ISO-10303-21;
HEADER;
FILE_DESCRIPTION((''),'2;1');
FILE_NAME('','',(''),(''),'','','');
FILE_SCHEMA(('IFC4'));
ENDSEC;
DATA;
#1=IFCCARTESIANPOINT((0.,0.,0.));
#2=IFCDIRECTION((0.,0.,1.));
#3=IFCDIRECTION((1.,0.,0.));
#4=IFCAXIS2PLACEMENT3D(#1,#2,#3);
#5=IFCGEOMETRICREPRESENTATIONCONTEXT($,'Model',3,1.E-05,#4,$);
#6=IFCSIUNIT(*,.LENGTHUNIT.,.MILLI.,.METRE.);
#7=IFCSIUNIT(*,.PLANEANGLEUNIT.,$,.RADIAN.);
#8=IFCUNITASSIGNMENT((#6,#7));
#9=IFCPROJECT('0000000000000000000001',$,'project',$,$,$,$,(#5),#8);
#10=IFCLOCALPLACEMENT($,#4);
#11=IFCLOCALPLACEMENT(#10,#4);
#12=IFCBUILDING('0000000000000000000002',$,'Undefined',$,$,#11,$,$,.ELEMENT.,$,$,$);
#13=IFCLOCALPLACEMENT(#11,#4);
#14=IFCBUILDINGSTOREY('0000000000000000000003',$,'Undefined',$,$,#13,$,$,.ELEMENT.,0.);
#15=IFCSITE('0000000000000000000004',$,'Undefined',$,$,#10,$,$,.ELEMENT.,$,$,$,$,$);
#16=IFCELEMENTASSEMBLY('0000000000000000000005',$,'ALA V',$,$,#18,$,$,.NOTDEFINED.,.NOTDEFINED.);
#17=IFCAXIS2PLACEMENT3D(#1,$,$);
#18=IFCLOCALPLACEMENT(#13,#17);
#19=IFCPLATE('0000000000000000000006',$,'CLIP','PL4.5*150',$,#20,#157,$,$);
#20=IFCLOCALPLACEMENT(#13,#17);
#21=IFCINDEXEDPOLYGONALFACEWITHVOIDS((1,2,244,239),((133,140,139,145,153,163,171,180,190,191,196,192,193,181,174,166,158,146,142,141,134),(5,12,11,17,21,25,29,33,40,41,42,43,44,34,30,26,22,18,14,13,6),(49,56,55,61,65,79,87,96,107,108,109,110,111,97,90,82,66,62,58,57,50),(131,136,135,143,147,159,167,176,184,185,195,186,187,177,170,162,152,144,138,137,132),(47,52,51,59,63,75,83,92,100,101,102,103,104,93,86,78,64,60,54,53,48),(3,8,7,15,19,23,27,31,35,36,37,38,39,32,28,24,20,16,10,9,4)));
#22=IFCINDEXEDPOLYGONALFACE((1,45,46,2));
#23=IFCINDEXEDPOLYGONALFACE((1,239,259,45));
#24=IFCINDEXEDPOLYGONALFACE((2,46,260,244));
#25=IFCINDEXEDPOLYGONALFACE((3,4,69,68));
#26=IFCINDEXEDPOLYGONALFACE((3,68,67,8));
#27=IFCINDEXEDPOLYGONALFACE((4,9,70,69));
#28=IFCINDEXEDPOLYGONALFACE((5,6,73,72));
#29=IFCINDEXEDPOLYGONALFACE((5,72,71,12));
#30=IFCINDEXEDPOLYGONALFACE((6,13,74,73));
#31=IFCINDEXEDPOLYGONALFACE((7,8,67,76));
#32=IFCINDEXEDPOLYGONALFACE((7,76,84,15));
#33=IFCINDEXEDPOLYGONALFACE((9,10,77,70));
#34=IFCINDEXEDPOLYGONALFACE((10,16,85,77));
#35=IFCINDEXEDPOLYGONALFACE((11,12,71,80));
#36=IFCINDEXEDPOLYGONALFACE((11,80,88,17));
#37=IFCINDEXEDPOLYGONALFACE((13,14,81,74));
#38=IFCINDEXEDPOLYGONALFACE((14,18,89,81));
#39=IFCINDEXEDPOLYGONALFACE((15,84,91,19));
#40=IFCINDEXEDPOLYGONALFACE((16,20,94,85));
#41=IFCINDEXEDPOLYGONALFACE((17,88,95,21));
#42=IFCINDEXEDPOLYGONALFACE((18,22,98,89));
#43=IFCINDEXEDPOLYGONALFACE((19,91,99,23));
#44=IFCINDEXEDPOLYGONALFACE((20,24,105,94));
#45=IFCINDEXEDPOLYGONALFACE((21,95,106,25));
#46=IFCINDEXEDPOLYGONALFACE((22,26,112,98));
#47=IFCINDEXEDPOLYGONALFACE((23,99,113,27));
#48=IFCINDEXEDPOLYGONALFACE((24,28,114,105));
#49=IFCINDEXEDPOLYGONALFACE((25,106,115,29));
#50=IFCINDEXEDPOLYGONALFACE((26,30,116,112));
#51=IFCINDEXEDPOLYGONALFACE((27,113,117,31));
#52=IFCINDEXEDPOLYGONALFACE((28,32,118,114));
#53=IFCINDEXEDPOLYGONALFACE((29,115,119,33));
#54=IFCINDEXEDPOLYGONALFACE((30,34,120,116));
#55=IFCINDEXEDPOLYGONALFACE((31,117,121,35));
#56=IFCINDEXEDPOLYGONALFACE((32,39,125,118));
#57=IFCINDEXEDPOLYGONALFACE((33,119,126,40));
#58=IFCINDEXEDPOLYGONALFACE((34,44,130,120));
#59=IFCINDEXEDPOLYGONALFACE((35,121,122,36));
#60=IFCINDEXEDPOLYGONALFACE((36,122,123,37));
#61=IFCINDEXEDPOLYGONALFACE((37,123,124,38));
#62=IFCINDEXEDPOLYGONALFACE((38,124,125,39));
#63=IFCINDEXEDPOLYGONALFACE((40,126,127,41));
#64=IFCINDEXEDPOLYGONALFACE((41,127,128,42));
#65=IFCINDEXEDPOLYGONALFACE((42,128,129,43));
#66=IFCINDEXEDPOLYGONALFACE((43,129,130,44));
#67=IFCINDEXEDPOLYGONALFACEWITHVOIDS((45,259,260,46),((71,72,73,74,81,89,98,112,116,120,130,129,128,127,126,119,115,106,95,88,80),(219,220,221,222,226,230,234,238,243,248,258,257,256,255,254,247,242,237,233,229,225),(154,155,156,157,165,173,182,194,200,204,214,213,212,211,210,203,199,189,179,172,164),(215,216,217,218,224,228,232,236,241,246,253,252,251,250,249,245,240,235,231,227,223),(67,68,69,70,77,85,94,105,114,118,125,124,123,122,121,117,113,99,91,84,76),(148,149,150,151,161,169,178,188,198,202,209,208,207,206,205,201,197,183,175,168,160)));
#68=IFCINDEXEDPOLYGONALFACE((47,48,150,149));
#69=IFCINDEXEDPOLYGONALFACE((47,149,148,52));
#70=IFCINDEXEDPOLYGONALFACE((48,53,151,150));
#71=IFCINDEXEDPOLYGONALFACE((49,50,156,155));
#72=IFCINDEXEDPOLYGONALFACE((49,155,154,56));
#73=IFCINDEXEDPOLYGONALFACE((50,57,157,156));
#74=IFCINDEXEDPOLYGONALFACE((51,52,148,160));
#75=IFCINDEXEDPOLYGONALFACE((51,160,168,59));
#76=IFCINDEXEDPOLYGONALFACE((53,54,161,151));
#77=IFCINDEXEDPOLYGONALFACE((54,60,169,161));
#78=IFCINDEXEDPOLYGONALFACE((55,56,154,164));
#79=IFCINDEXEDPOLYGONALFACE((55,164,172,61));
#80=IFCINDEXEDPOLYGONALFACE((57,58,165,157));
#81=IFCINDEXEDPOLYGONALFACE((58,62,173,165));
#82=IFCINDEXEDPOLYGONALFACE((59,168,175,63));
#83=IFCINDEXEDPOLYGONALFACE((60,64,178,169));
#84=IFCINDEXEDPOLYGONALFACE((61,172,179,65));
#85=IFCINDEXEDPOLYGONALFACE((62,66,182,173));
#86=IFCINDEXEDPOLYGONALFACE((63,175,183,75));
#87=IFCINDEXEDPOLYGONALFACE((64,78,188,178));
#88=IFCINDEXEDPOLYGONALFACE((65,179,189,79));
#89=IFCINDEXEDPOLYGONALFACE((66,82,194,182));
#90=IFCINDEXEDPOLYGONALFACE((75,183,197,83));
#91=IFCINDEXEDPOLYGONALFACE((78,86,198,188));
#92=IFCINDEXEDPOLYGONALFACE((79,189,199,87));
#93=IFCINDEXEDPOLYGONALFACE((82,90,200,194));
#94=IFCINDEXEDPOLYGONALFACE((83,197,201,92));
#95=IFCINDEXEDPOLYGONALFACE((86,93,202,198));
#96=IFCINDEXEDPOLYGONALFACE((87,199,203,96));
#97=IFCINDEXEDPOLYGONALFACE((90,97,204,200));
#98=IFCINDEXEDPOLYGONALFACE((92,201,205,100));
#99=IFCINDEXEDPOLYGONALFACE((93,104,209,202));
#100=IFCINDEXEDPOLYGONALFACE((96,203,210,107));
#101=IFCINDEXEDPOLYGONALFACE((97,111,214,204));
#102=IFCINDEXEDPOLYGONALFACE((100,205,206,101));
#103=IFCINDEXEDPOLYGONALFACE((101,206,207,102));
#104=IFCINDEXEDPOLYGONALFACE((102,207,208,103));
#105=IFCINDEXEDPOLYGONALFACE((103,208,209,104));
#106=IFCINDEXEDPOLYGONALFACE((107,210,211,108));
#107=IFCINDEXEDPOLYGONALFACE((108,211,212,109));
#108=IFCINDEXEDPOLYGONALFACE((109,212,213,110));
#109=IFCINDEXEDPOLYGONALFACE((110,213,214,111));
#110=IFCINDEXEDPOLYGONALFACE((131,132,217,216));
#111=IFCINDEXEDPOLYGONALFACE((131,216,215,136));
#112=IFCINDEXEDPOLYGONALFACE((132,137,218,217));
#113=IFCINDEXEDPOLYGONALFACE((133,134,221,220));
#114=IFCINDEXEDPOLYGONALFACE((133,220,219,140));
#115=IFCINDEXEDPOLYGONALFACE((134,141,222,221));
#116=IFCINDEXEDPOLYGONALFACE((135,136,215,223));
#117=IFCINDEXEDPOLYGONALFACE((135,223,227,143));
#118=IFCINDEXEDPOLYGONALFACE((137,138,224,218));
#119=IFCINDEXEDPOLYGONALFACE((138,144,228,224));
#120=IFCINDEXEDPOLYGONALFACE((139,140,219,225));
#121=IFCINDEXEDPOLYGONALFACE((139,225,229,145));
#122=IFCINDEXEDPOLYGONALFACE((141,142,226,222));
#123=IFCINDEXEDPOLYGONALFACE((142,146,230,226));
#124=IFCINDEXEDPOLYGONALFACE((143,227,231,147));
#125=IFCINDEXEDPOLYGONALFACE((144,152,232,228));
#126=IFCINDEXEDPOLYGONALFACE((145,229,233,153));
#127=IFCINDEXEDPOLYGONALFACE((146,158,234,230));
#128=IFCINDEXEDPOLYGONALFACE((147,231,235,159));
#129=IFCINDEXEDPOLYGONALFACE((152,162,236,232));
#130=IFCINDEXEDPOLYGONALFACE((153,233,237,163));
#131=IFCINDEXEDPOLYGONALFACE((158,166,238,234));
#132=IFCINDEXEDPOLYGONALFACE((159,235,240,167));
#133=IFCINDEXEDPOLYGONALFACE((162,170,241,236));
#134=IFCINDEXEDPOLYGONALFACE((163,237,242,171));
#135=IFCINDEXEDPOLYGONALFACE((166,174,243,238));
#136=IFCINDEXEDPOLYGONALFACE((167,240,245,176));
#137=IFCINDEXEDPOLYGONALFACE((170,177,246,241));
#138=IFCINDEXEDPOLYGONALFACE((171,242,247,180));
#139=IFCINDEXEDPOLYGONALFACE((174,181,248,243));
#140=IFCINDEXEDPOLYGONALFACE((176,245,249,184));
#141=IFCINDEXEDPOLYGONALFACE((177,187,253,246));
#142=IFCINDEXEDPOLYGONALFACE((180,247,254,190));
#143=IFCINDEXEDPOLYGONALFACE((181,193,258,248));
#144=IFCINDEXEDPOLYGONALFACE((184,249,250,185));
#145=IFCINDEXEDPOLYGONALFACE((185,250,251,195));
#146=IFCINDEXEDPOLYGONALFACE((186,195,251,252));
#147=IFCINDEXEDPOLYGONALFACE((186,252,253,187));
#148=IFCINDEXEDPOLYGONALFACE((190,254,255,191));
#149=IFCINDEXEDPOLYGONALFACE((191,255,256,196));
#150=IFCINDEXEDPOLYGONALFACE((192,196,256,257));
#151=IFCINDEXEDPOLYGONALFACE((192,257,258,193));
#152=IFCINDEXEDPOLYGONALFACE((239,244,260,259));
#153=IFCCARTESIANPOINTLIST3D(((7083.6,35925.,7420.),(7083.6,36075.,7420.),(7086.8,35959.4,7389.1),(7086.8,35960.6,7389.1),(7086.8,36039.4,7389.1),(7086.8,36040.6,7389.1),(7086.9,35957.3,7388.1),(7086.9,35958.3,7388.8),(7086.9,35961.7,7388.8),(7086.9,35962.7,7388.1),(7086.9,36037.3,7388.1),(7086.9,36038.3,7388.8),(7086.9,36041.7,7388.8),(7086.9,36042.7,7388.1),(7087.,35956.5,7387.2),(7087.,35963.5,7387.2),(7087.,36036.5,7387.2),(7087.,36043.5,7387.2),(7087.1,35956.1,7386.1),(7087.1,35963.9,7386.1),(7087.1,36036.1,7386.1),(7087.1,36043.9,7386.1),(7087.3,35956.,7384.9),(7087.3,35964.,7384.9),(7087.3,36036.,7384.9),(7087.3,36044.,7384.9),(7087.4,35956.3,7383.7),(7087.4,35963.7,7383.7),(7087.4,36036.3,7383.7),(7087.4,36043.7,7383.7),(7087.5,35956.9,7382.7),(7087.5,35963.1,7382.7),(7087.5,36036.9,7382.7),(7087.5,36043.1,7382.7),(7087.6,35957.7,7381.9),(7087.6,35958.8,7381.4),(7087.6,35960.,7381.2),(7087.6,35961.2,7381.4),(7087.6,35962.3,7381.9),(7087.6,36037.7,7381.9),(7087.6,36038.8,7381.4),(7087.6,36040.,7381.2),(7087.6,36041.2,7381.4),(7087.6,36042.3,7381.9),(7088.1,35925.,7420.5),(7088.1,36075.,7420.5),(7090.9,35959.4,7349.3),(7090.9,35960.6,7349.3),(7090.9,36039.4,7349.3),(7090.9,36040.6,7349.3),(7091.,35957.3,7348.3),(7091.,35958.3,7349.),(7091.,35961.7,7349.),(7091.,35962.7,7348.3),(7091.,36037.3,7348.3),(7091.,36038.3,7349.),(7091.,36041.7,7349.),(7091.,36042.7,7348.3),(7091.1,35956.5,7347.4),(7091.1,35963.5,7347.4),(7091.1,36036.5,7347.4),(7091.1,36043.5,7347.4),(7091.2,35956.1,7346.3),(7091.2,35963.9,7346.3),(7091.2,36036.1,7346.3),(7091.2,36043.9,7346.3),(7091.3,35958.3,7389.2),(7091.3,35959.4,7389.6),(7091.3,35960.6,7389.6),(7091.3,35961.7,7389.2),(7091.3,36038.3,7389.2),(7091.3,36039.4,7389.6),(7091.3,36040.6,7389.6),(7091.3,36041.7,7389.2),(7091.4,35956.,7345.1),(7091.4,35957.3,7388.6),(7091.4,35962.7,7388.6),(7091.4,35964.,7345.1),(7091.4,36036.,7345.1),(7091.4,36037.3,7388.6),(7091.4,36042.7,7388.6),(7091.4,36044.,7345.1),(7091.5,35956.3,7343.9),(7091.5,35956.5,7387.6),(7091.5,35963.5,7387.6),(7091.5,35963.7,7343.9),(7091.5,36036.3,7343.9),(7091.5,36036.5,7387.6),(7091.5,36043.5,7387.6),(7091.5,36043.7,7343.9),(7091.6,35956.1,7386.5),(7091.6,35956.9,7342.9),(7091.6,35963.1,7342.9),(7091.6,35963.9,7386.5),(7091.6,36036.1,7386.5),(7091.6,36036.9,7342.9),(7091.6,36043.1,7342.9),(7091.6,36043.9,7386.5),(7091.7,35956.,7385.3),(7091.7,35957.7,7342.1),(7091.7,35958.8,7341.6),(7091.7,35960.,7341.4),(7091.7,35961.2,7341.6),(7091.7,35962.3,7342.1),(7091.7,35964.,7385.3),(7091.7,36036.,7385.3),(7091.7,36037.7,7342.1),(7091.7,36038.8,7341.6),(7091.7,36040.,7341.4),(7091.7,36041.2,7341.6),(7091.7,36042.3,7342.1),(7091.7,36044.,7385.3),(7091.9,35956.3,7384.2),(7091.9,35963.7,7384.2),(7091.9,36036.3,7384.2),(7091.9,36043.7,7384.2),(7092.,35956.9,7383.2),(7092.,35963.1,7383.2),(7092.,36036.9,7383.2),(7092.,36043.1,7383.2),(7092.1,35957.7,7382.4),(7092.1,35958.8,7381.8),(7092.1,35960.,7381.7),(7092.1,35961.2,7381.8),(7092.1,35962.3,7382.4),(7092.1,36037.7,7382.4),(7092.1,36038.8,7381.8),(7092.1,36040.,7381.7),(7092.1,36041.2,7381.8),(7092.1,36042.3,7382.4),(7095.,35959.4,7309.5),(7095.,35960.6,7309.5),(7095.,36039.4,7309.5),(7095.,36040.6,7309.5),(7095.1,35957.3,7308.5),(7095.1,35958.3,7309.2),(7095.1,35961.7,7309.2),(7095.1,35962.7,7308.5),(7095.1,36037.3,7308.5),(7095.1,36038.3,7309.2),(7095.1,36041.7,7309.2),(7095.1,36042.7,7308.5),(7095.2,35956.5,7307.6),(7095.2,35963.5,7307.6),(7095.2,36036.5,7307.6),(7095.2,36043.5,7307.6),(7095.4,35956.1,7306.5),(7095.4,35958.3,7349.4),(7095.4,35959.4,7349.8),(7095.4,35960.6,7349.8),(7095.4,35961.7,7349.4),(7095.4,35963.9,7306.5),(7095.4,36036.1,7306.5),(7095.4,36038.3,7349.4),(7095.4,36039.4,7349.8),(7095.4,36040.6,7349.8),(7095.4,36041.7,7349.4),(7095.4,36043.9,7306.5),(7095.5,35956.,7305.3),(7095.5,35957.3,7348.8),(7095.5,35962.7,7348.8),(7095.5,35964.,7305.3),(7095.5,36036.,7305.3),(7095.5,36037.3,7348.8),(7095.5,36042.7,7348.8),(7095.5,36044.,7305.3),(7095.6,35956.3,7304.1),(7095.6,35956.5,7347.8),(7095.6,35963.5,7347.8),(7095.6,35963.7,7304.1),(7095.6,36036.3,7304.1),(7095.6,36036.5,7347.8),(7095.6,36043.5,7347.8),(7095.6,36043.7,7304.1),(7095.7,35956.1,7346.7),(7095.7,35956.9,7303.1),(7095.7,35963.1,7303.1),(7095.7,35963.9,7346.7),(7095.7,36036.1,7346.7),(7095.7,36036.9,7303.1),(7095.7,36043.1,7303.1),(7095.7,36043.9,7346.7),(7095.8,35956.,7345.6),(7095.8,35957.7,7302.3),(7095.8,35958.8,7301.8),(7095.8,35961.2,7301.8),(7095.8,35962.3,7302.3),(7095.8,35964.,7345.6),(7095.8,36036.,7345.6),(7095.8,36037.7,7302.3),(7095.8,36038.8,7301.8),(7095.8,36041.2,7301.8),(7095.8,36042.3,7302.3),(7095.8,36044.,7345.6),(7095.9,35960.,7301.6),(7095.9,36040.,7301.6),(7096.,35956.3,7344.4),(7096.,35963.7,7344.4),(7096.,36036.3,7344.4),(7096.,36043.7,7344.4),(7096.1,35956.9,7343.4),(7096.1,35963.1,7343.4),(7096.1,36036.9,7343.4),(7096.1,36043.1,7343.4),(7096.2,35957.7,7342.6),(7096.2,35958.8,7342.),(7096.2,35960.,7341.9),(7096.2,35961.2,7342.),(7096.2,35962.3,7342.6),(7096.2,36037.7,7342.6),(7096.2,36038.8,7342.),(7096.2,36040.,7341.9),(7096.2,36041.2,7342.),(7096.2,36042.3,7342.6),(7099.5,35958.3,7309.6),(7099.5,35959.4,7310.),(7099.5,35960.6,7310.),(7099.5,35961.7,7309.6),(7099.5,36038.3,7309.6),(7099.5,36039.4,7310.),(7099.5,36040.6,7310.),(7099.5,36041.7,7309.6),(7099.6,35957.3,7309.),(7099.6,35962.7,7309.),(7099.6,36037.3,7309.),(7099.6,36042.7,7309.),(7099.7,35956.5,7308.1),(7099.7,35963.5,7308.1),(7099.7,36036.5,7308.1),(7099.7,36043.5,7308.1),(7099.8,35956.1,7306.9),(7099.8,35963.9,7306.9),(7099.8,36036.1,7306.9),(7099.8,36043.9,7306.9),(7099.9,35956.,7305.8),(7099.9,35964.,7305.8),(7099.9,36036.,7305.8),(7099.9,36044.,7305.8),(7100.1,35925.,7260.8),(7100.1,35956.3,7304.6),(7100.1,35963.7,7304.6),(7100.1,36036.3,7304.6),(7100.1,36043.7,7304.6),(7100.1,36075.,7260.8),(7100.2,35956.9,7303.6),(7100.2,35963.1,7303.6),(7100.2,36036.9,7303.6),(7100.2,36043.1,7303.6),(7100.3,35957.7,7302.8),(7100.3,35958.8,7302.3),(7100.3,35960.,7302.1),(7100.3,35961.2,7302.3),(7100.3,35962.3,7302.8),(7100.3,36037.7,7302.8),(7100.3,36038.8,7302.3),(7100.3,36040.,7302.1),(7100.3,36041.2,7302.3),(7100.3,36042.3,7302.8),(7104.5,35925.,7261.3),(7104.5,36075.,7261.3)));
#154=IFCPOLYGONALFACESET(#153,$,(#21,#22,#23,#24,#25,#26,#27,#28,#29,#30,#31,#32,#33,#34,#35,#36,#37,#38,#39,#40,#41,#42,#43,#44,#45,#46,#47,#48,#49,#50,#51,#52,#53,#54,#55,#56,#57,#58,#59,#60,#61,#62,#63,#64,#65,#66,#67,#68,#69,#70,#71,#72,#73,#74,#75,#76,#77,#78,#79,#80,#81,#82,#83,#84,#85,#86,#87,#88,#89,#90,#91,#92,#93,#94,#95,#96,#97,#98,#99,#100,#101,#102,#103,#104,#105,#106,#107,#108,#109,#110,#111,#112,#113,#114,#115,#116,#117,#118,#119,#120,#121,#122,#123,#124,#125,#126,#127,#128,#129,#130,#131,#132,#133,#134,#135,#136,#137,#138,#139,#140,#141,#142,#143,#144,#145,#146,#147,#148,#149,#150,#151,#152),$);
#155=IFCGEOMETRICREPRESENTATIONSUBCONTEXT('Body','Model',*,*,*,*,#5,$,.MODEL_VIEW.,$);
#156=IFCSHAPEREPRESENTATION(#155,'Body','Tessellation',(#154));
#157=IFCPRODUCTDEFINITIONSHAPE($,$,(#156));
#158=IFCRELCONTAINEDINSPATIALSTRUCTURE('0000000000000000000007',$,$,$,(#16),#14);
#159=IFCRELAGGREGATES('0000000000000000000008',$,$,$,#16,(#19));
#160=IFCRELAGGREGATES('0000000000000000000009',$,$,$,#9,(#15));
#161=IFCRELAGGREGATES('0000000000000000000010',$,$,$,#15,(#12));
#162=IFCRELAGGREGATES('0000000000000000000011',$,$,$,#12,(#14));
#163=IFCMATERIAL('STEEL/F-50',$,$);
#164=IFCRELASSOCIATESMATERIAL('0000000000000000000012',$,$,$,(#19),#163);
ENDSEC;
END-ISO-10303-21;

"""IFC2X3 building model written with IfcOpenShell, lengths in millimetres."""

from ifc_helpers import new_model, si_unit, frame, origin_with_axes, origin_2d_with_axis, place, context, subcontext, project, spatial, polyline, circle, outline, extrude, source, transform, mapped, material, element, aggregate, save


model = new_model("IFC2X3")

# Units and contexts
model_context = context("Model", 3, precision=1e-05, world=origin_with_axes())
body_context = subcontext(model_context, "Body", "Model", "MODEL_VIEW")
ifc_project = project(units=[si_unit("LENGTHUNIT", "METRE", prefix="MILLI"), si_unit("PLANEANGLEUNIT", "RADIAN")], contexts=[model_context])

# Site, building, storey
site_placement = place(None, origin_with_axes())
site = spatial("IfcSite", under=ifc_project, at=site_placement, Name="Undefined", CompositionType="ELEMENT")
building_placement = place(site_placement, origin_with_axes())
building = spatial("IfcBuilding", under=site, at=building_placement, Name="Undefined", CompositionType="ELEMENT")
storey_placement = place(building_placement, origin_with_axes())
storey = spatial("IfcBuildingStorey", under=building, at=storey_placement, Name="Undefined", CompositionType="ELEMENT", Elevation=0.0)

# Element assembly
assembly_1_placement = place(storey_placement, origin_with_axes())
assembly_1 = element("IfcElementAssembly", 1, at=assembly_1_placement, inside=storey, Name="ALA V", AssemblyPlace="NOTDEFINED", PredefinedType="NOTDEFINED")
ifc_material_1 = material(Name="STEEL/F-50")

# Plate, openings
shared_shape_1 = source(origin_with_axes(), body_context, "Body", "SweptSolid", [
    extrude(circle(Radius=4.0, at=origin_2d_with_axis()), frame((0.0, -4.6, 0.0), z_axis=(0.0, 1.0, 0.0), x_axis=(1.0, 0.0, 0.0)), (0.0, 0.0, 1.0), 4.7),
])
plate_1_placement = place(assembly_1_placement, frame((7085.9, 35925.0, 7420.2), z_axis=(0.994727, 0.0, 0.102562), x_axis=(0.102562, 0.0, -0.994727)))
plate_1 = element("IfcPlate", 2, at=plate_1_placement, material=ifc_material_1, Name="CLIP", Description="PL4.5*150", context=body_context, shape_type="SweptSolid", body=[
    extrude(outline(polyline([(0.0, 0.0), (160.0, 0.0), (160.0, 150.0), (0.0, 150.0), (0.0, 0.0)])), frame((0.0, 0.0, -2.2), z_axis=(0.0, 0.0, 1.0), x_axis=(1.0, 0.0, 0.0)), (0.0, 0.0, 1.0), 4.5),
])
opening_1_placement = place(assembly_1_placement, frame((7087.2, 36040.0, 7385.2), z_axis=(0.0, 1.0, 0.0), x_axis=(0.102562, 0.0, -0.994727)))
element("IfcOpeningElement", 3, at=opening_1_placement, cuts=plate_1, ObjectType="Opening", context=body_context, shape_type="MappedRepresentation", body=[
    mapped(shared_shape_1, transform((0.0, 0.0, 0.0))),
    mapped(shared_shape_1, transform((40.0, 0.0, 0.0))),
    mapped(shared_shape_1, transform((80.0, 0.0, 0.0))),
])
opening_2_placement = place(assembly_1_placement, frame((7087.2, 35960.0, 7385.2), z_axis=(0.0, 1.0, 0.0), x_axis=(0.102562, 0.0, -0.994727)))
element("IfcOpeningElement", 4, at=opening_2_placement, cuts=plate_1, ObjectType="Opening", context=body_context, shape_type="MappedRepresentation", body=[
    mapped(shared_shape_1, transform((0.0, 0.0, 0.0))),
    mapped(shared_shape_1, transform((40.0, 0.0, 0.0))),
    mapped(shared_shape_1, transform((80.0, 0.0, 0.0))),
])

aggregate(assembly_1, [plate_1])

save(model, "model.ifc")
